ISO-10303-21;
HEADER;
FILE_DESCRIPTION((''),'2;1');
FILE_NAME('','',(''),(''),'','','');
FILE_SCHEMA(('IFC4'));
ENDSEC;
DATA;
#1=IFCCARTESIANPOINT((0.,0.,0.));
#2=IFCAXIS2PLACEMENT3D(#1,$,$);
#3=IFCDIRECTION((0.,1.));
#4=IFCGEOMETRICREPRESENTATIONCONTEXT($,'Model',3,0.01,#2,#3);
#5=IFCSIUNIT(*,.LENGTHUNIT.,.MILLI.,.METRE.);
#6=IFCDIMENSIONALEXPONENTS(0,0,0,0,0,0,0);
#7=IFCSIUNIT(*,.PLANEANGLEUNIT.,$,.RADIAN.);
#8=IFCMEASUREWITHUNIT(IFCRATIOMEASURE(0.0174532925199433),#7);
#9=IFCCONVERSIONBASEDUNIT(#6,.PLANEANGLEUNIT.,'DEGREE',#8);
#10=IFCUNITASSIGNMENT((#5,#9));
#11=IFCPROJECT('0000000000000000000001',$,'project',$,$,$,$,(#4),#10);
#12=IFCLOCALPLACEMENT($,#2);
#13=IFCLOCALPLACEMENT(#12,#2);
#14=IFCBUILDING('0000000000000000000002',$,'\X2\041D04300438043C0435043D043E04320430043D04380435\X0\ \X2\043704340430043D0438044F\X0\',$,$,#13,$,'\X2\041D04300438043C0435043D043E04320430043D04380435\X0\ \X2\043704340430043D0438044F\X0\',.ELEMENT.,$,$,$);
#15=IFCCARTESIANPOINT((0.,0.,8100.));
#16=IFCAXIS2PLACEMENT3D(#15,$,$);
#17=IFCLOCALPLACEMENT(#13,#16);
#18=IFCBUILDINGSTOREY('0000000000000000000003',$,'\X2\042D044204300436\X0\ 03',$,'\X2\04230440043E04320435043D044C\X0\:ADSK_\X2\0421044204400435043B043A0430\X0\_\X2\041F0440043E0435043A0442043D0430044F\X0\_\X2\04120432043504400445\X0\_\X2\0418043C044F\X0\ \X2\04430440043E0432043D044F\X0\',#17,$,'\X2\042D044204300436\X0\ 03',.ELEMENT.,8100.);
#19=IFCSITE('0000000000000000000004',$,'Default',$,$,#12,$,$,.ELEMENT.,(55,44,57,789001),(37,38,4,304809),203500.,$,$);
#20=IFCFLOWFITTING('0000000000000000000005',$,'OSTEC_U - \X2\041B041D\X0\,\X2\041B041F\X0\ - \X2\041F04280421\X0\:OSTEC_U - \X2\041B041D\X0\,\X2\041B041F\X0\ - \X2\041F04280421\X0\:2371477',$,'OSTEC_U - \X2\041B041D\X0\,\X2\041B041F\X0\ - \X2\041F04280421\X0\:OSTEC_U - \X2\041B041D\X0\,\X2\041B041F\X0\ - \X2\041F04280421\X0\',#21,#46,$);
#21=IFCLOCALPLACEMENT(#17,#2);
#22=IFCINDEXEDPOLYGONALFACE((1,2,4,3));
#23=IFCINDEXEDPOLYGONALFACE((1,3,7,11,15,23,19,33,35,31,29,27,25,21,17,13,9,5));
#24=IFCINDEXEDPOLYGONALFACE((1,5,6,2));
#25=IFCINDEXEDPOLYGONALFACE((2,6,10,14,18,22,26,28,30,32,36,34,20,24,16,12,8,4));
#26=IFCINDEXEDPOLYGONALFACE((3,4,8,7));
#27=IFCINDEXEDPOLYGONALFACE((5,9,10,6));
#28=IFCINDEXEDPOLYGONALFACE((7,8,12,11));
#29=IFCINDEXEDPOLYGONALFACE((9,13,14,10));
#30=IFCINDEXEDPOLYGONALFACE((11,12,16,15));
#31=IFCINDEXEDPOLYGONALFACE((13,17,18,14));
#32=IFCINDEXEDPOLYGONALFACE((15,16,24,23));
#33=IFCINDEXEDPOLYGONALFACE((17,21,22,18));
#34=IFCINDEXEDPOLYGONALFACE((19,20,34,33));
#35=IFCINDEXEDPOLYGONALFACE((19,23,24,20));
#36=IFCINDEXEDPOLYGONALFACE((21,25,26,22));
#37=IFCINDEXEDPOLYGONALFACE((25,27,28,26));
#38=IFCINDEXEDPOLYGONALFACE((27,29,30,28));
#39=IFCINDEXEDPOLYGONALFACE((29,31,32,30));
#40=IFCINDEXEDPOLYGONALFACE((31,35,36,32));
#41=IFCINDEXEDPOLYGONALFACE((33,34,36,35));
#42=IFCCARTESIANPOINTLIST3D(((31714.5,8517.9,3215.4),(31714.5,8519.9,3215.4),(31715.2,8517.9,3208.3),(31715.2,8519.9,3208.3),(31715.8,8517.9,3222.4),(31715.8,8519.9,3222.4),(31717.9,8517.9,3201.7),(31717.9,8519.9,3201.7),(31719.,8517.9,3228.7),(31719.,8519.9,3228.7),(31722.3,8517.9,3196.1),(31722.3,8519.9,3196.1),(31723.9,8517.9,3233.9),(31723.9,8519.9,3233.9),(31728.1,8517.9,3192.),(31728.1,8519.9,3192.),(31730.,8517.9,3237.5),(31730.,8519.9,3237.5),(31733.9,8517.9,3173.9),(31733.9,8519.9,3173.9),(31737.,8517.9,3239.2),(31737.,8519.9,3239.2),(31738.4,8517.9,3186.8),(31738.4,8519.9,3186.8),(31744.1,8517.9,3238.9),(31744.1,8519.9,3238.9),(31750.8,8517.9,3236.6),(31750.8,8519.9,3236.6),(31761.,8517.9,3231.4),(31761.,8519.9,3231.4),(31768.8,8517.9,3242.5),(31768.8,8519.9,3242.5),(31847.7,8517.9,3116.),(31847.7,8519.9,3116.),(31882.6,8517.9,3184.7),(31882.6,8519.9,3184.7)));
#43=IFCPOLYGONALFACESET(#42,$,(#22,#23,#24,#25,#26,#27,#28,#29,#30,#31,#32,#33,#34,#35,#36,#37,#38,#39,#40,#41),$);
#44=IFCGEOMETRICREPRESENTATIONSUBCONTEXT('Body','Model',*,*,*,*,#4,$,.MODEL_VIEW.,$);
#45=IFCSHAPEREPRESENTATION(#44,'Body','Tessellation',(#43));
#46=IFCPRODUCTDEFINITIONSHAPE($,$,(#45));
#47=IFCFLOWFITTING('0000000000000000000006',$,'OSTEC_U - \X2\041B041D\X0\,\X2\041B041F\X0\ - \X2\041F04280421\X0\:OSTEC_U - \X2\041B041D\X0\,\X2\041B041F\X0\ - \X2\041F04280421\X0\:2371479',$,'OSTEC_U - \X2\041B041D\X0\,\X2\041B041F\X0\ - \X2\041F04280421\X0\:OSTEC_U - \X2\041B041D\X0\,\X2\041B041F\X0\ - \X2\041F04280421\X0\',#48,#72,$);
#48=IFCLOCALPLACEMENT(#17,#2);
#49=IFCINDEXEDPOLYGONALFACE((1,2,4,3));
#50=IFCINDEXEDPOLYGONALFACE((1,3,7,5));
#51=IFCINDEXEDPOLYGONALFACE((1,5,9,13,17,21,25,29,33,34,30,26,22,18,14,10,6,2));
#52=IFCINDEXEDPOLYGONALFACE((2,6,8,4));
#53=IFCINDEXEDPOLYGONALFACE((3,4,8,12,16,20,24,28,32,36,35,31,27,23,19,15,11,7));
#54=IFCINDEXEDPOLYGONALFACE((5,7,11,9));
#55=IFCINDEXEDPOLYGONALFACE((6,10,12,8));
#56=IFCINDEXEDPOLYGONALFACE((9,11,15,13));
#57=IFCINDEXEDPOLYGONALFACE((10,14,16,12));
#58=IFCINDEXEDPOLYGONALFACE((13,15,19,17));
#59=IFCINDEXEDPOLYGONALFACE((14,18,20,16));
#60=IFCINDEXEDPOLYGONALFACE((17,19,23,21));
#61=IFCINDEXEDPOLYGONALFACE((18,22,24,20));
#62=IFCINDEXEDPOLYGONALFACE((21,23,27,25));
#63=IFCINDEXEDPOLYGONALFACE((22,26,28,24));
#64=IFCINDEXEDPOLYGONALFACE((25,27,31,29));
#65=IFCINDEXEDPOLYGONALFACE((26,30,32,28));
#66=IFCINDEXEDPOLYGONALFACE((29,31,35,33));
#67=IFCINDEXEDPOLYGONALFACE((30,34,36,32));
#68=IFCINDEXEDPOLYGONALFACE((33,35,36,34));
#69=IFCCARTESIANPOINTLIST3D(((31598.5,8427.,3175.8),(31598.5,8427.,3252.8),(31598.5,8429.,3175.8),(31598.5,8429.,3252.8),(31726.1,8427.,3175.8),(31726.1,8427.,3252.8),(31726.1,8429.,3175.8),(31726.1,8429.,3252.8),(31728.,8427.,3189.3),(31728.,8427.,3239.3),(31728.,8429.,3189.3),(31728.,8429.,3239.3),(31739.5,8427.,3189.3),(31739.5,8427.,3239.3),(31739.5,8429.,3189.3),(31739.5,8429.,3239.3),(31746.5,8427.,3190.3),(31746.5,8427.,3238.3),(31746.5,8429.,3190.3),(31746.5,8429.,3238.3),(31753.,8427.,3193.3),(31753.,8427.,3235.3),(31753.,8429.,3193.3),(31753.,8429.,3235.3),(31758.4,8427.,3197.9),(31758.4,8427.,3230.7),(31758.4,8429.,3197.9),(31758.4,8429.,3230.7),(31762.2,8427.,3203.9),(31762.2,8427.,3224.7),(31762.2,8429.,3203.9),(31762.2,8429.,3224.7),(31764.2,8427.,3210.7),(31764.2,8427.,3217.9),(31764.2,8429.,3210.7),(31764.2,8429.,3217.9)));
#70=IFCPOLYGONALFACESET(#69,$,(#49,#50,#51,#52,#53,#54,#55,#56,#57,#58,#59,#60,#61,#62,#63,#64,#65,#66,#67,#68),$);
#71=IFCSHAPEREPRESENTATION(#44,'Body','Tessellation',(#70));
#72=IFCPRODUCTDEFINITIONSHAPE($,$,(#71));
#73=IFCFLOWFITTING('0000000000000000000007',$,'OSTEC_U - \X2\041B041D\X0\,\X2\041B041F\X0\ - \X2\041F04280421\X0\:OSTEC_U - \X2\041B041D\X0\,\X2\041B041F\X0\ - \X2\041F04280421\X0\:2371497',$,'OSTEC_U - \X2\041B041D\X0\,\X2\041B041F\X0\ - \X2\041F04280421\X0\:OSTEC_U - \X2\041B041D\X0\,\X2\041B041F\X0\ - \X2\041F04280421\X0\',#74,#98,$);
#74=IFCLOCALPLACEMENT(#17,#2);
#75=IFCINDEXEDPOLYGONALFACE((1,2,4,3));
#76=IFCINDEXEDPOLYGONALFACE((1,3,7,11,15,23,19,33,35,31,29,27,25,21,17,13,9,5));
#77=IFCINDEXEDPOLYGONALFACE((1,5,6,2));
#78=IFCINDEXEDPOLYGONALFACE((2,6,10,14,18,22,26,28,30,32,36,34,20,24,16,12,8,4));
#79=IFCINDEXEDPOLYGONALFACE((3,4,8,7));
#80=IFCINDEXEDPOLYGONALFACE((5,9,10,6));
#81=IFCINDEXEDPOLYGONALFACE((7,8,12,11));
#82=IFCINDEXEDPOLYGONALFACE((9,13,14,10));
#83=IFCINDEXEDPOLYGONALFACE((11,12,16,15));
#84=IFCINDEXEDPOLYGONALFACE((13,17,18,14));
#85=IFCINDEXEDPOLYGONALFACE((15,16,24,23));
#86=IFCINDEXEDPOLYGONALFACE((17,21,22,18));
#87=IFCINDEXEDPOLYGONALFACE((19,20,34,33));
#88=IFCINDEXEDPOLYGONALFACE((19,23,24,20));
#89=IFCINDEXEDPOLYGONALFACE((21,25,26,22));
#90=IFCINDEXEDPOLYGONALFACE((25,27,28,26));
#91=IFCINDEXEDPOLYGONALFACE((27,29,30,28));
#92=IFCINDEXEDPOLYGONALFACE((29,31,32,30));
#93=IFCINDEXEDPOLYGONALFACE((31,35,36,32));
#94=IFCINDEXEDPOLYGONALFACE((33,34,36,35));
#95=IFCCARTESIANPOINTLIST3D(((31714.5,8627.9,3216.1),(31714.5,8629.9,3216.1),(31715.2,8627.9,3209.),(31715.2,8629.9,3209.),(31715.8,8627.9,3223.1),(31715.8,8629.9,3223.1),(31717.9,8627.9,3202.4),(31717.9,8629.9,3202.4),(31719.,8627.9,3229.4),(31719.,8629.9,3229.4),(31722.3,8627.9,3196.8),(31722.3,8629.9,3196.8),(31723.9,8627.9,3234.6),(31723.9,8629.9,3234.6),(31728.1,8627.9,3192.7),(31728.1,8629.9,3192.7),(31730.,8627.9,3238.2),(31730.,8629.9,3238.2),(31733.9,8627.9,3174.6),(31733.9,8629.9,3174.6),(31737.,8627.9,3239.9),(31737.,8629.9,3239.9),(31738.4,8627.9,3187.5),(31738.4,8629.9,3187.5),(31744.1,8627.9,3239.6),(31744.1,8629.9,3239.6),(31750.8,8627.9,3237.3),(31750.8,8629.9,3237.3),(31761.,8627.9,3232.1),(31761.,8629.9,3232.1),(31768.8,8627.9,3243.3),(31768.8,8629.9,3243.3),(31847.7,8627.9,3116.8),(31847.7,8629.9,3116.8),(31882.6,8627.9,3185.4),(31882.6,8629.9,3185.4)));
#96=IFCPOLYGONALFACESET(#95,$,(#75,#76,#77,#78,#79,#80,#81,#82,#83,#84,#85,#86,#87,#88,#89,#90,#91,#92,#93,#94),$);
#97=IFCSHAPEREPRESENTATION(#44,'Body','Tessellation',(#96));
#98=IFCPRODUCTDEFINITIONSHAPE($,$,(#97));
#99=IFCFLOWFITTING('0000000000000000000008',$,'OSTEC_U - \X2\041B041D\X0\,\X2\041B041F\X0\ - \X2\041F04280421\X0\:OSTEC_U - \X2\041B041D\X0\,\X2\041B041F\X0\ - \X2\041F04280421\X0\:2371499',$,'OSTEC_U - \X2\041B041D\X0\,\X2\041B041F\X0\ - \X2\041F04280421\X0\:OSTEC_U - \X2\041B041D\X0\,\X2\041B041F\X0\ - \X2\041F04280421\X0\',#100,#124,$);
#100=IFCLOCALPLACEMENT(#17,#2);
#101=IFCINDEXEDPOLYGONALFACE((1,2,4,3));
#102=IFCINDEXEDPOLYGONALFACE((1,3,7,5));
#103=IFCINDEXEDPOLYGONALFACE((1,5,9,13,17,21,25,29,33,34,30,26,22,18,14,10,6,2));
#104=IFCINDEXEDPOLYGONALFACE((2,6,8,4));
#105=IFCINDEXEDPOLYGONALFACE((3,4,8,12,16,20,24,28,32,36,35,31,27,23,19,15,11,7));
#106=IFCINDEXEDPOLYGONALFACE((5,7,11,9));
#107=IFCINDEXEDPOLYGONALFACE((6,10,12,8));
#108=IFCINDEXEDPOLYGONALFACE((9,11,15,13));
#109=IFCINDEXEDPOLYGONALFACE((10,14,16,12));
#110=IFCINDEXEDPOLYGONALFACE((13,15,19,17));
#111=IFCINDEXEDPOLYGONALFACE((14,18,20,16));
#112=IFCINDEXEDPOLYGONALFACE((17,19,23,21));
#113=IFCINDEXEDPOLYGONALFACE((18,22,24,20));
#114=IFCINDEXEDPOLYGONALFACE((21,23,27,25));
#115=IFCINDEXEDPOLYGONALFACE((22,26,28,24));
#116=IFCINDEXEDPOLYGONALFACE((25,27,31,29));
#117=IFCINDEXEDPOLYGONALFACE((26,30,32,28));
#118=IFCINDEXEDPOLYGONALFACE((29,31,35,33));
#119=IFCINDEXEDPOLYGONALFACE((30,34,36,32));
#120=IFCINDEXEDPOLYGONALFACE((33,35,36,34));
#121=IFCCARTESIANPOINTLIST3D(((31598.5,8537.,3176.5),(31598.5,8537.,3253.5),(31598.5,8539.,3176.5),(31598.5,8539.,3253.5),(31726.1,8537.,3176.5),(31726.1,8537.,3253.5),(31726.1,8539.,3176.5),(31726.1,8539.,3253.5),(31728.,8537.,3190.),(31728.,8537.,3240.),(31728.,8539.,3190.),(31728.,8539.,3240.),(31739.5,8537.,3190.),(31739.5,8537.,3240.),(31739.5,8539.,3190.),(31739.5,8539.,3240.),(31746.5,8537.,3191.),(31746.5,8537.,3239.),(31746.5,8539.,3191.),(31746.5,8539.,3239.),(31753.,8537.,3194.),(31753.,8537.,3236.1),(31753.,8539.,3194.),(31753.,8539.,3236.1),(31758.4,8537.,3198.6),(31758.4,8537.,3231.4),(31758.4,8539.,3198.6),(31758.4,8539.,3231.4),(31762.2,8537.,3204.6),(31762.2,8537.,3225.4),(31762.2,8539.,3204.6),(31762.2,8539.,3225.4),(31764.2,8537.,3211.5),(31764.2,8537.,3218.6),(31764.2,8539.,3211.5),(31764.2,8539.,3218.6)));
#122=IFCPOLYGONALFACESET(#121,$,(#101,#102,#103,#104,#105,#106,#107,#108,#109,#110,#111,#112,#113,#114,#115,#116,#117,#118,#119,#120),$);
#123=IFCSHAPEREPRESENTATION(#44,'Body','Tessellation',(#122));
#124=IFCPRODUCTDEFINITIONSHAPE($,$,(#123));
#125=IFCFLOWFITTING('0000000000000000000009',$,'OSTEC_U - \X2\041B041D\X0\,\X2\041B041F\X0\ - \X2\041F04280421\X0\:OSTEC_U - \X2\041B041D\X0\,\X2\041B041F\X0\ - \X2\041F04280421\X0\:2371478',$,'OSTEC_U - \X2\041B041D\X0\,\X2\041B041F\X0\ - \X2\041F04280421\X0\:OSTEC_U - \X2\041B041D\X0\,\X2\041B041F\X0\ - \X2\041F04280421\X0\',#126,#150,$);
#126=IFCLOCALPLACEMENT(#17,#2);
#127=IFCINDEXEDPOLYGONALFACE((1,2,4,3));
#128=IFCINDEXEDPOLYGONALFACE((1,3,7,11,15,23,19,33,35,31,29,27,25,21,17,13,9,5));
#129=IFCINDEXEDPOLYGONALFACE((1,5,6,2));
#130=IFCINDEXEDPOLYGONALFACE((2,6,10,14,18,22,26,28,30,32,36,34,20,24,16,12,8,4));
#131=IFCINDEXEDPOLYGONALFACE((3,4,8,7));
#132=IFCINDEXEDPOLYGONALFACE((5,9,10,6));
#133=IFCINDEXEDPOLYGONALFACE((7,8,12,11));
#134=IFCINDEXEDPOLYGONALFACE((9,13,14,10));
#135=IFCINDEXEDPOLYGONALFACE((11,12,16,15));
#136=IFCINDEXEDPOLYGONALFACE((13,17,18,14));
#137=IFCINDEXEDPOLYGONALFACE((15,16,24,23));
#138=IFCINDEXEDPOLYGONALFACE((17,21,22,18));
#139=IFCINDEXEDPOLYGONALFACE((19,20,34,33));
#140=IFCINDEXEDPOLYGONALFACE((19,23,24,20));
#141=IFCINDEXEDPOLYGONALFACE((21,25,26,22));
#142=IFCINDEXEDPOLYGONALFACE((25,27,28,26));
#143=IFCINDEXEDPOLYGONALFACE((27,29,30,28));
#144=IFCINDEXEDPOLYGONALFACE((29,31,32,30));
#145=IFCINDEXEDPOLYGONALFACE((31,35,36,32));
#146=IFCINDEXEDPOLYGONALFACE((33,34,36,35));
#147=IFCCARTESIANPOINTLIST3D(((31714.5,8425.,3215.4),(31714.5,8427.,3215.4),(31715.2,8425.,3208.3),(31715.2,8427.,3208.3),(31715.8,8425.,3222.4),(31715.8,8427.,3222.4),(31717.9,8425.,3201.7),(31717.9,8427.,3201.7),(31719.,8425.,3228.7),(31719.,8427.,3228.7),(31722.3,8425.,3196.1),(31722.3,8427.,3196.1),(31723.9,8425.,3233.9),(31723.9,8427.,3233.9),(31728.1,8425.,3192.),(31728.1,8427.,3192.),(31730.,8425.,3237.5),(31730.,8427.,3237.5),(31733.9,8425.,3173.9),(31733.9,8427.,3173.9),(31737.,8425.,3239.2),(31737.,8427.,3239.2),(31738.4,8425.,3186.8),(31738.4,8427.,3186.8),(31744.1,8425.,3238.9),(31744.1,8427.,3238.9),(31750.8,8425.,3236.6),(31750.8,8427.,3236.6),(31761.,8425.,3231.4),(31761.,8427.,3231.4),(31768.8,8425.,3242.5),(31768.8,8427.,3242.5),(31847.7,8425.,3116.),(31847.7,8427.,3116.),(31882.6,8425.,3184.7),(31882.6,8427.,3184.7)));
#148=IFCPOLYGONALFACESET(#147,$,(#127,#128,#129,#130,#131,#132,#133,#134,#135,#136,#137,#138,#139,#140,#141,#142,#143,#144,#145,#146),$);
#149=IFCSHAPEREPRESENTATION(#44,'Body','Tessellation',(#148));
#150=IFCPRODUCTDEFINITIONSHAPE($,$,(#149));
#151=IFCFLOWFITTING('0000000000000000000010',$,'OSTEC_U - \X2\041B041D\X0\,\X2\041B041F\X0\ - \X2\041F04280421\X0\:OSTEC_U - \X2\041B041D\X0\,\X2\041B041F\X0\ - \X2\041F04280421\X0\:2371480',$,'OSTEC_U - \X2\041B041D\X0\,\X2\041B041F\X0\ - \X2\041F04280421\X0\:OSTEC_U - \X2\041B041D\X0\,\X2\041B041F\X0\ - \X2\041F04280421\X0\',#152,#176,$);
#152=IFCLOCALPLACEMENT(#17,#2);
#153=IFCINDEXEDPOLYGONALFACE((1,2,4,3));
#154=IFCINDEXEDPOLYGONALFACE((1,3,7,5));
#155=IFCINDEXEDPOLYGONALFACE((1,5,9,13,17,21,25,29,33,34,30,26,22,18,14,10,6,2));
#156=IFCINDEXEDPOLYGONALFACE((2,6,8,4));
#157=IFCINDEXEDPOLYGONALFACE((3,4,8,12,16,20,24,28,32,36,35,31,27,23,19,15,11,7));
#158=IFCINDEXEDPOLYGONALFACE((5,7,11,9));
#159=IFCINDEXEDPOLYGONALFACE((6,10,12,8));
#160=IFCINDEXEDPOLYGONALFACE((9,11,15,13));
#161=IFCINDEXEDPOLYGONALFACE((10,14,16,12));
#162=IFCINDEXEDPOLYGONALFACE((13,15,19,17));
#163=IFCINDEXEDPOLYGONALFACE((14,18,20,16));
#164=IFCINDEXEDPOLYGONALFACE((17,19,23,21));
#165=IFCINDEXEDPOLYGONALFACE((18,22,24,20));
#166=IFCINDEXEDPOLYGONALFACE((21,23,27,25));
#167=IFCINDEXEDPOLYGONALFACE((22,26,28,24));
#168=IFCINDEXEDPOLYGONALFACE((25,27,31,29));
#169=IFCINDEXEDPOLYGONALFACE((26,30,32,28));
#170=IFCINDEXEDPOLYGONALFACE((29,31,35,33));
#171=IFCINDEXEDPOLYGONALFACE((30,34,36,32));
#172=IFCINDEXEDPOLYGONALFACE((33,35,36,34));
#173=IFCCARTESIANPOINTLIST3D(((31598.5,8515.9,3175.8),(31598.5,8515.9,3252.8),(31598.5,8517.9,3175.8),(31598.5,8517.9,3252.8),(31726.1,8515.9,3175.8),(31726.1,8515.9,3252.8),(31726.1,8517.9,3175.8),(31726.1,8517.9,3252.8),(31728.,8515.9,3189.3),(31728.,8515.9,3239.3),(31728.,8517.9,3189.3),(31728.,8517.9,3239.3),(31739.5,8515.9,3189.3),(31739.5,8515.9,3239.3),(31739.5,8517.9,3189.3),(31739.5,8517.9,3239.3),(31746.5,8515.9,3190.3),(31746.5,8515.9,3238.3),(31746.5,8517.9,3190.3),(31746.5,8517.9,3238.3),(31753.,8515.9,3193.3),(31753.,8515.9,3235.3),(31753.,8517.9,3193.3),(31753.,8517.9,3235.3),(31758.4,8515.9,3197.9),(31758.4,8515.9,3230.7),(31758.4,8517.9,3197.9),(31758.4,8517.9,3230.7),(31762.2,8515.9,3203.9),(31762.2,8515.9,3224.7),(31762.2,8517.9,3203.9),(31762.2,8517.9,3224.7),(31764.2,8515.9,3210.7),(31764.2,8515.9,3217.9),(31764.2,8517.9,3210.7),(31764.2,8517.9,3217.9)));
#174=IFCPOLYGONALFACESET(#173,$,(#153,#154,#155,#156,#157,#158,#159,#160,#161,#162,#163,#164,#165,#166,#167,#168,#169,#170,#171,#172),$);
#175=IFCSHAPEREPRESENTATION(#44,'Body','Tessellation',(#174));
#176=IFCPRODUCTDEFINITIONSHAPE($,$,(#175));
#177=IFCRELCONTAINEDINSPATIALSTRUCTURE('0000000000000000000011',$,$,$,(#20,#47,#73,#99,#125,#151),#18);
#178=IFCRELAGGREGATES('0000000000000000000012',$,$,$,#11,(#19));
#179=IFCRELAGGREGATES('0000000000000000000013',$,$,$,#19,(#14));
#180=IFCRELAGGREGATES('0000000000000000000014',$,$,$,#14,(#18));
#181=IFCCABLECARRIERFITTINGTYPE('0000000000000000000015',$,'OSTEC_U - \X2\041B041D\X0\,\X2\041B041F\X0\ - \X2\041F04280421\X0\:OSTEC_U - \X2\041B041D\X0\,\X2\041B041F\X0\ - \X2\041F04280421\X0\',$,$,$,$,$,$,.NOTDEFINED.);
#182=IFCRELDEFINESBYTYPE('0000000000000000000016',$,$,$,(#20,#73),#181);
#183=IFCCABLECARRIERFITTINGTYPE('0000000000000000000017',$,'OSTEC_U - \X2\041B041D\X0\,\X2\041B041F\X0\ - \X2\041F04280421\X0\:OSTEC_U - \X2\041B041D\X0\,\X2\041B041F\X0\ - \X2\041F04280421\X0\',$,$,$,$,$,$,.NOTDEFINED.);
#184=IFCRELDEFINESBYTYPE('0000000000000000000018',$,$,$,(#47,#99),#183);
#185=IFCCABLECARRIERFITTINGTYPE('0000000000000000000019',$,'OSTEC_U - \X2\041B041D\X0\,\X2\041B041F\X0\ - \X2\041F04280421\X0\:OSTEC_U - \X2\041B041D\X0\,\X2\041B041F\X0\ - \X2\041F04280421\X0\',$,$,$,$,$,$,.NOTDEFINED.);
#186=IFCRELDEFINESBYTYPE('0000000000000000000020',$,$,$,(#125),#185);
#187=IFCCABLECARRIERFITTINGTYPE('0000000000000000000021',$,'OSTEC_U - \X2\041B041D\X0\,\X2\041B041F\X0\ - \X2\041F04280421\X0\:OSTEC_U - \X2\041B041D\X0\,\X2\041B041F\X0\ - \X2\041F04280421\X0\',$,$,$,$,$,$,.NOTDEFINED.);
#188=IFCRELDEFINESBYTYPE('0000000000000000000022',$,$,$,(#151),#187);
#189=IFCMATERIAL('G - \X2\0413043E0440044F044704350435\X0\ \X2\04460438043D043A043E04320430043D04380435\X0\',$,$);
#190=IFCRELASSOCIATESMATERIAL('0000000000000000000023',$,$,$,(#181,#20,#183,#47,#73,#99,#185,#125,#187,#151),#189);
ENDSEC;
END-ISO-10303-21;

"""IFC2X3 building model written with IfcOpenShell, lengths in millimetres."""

from ifc_helpers import new_model, entity, si_unit, converted_unit, direction, frame, frame_2d, origin, place, context, subcontext, project, spatial, polyline, circle_curve, parameter, trimmed, segment, composite_curve, outline, extrude, source, transform, mapped, material, type_object, type_shapes, element, save


model = new_model("IFC2X3")

# Units and contexts
model_context = context("Model", 3, precision=0.01, world=origin(), true_north=direction((0.0, 1.0)))
body_context = subcontext(model_context, "Body", "Model", "MODEL_VIEW")
ifc_project = project(units=[si_unit("LENGTHUNIT", "METRE", prefix="MILLI"), converted_unit("PLANEANGLEUNIT", "DEGREE", entity("IfcRatioMeasure", 0.0174532925199433), si_unit("PLANEANGLEUNIT", "RADIAN"), dimensions=[0, 0, 0, 0, 0, 0, 0])], contexts=[model_context])

# Site, building, storey
site_placement = place(None, origin())
site = spatial("IfcSite", under=ifc_project, at=site_placement, Name="Default", CompositionType="ELEMENT", RefLatitude=(55, 44, 57, 789001), RefLongitude=(37, 38, 4, 304809), RefElevation=203500.0)
building_placement = place(site_placement, origin())
building = spatial("IfcBuilding", under=site, at=building_placement, Name="Наименование здания", LongName="Наименование здания", CompositionType="ELEMENT")
storey_placement = place(building_placement, frame((0.0, 0.0, 8100.0)))
storey = spatial("IfcBuildingStorey", under=building, at=storey_placement, Name="Этаж 03", ObjectType="Уровень:ADSK_Стрелка_Проектная_Вверх_Имя уровня", LongName="Этаж 03", CompositionType="ELEMENT", Elevation=8100.0)

# Flow fittings
ifc_material_1 = material(Name="G - Горячее цинкование")
cable_carrier_fitting_type_1 = type_object("IfcCableCarrierFittingType", Name="OSTEC_U - ЛН,ЛП - ПШС:OSTEC_U - ЛН,ЛП - ПШС", PredefinedType="NOTDEFINED", material=ifc_material_1)
shared_shape_1 = source(origin(), body_context, "Body", "SweptSolid", [
    extrude(outline(composite_curve([segment(trimmed(circle_curve(frame_2d((-41.5, 0.0), x_axis=(1.0, 0.0)), 25.0), [parameter(90.0)], [parameter(270.0)], True, "PARAMETER"), True, "CONTINUOUS"), segment(polyline([(-41.5, -25.0), (-30.0, -25.0)]), True, "CONTINUOUS"), segment(polyline([(-30.0, -25.0), (-28.1, -38.5)]), True, "CONTINUOUS"), segment(polyline([(-28.1, -38.5), (99.5, -38.5)]), True, "CONTINUOUS"), segment(polyline([(99.5, -38.5), (99.5, 38.5)]), True, "CONTINUOUS"), segment(polyline([(99.5, 38.5), (-28.1, 38.5)]), True, "CONTINUOUS"), segment(polyline([(-28.1, 38.5), (-30.0, 25.0)]), True, "CONTINUOUS"), segment(polyline([(-30.0, 25.0), (-41.5, 25.0)]), True, "CONTINUOUS")], self_intersect=False)), frame((41.5, 0.0, 0.0), z_axis=(0.0, 0.0, -1.0), x_axis=(1.0, 0.0, 0.0)), (0.0, 0.0, -1.0), 2.0),
])
type_shapes(cable_carrier_fitting_type_1, [shared_shape_1])
flow_fitting_1_placement = place(storey_placement, frame((31739.5, 8517.9, 3214.3), z_axis=(0.0, 1.0, 0.0), x_axis=(0.891238, 0.0, -0.453536)))
element("IfcFlowFitting", 1, at=flow_fitting_1_placement, inside=storey, type_object=cable_carrier_fitting_type_1, material=ifc_material_1, Name="OSTEC_U - ЛН,ЛП - ПШС:OSTEC_U - ЛН,ЛП - ПШС:2371477", ObjectType="OSTEC_U - ЛН,ЛП - ПШС:OSTEC_U - ЛН,ЛП - ПШС", context=body_context, shape_type="MappedRepresentation", body=[
    mapped(shared_shape_1, transform((0.0, 0.0, 0.0), scale=1.0)),
])
cable_carrier_fitting_type_2 = type_object("IfcCableCarrierFittingType", Name="OSTEC_U - ЛН,ЛП - ПШС:OSTEC_U - ЛН,ЛП - ПШС", PredefinedType="NOTDEFINED", material=ifc_material_1)
type_shapes(cable_carrier_fitting_type_2, [shared_shape_1])
flow_fitting_2_placement = place(storey_placement, frame((31739.5, 8429.0, 3214.3), z_axis=(0.0, -1.0, 0.0), x_axis=(-1.0, 0.0, 0.0)))
element("IfcFlowFitting", 2, at=flow_fitting_2_placement, inside=storey, type_object=cable_carrier_fitting_type_2, material=ifc_material_1, Name="OSTEC_U - ЛН,ЛП - ПШС:OSTEC_U - ЛН,ЛП - ПШС:2371479", ObjectType="OSTEC_U - ЛН,ЛП - ПШС:OSTEC_U - ЛН,ЛП - ПШС", context=body_context, shape_type="MappedRepresentation", body=[
    mapped(shared_shape_1, transform((0.0, 0.0, 0.0), scale=1.0)),
])
flow_fitting_3_placement = place(storey_placement, frame((31739.5, 8627.9, 3215.0), z_axis=(0.0, 1.0, 0.0), x_axis=(0.891243, 0.0, -0.453526)))
element("IfcFlowFitting", 3, at=flow_fitting_3_placement, inside=storey, type_object=cable_carrier_fitting_type_1, material=ifc_material_1, Name="OSTEC_U - ЛН,ЛП - ПШС:OSTEC_U - ЛН,ЛП - ПШС:2371497", ObjectType="OSTEC_U - ЛН,ЛП - ПШС:OSTEC_U - ЛН,ЛП - ПШС", context=body_context, shape_type="MappedRepresentation", body=[
    mapped(shared_shape_1, transform((0.0, 0.0, 0.0), scale=1.0)),
])
flow_fitting_4_placement = place(storey_placement, frame((31739.5, 8539.0, 3215.0), z_axis=(0.0, -1.0, 0.0), x_axis=(-1.0, 0.0, 0.0)))
element("IfcFlowFitting", 4, at=flow_fitting_4_placement, inside=storey, type_object=cable_carrier_fitting_type_2, material=ifc_material_1, Name="OSTEC_U - ЛН,ЛП - ПШС:OSTEC_U - ЛН,ЛП - ПШС:2371499", ObjectType="OSTEC_U - ЛН,ЛП - ПШС:OSTEC_U - ЛН,ЛП - ПШС", context=body_context, shape_type="MappedRepresentation", body=[
    mapped(shared_shape_1, transform((0.0, 0.0, 0.0), scale=1.0)),
])
cable_carrier_fitting_type_3 = type_object("IfcCableCarrierFittingType", Name="OSTEC_U - ЛН,ЛП - ПШС:OSTEC_U - ЛН,ЛП - ПШС", PredefinedType="NOTDEFINED", material=ifc_material_1)
shared_shape_2 = source(origin(), body_context, "Body", "SweptSolid", [
    extrude(outline(composite_curve([segment(trimmed(circle_curve(frame_2d((-41.5, 0.0), x_axis=(1.0, 0.0)), 25.0), [parameter(90.0)], [parameter(270.0)], True, "PARAMETER"), True, "CONTINUOUS"), segment(polyline([(-41.5, -25.0), (-30.0, -25.0)]), True, "CONTINUOUS"), segment(polyline([(-30.0, -25.0), (-28.1, -38.5)]), True, "CONTINUOUS"), segment(polyline([(-28.1, -38.5), (99.5, -38.5)]), True, "CONTINUOUS"), segment(polyline([(99.5, -38.5), (99.5, 38.5)]), True, "CONTINUOUS"), segment(polyline([(99.5, 38.5), (-28.1, 38.5)]), True, "CONTINUOUS"), segment(polyline([(-28.1, 38.5), (-30.0, 25.0)]), True, "CONTINUOUS"), segment(polyline([(-30.0, 25.0), (-41.5, 25.0)]), True, "CONTINUOUS")], self_intersect=False)), frame((41.5, 0.0, 0.0)), (0.0, 0.0, 1.0), 2.0),
])
type_shapes(cable_carrier_fitting_type_3, [shared_shape_2])
flow_fitting_5_placement = place(storey_placement, frame((31739.5, 8427.0, 3214.3), z_axis=(0.0, -1.0, 0.0), x_axis=(0.891238, 0.0, -0.453536)))
element("IfcFlowFitting", 5, at=flow_fitting_5_placement, inside=storey, type_object=cable_carrier_fitting_type_3, material=ifc_material_1, Name="OSTEC_U - ЛН,ЛП - ПШС:OSTEC_U - ЛН,ЛП - ПШС:2371478", ObjectType="OSTEC_U - ЛН,ЛП - ПШС:OSTEC_U - ЛН,ЛП - ПШС", context=body_context, shape_type="MappedRepresentation", body=[
    mapped(shared_shape_2, transform((0.0, 0.0, 0.0), scale=1.0)),
])
cable_carrier_fitting_type_4 = type_object("IfcCableCarrierFittingType", Name="OSTEC_U - ЛН,ЛП - ПШС:OSTEC_U - ЛН,ЛП - ПШС", PredefinedType="NOTDEFINED", material=ifc_material_1)
type_shapes(cable_carrier_fitting_type_4, [shared_shape_2])
flow_fitting_6_placement = place(storey_placement, frame((31739.5, 8515.9, 3214.3), z_axis=(0.0, 1.0, 0.0), x_axis=(-1.0, 0.0, 0.0)))
element("IfcFlowFitting", 6, at=flow_fitting_6_placement, inside=storey, type_object=cable_carrier_fitting_type_4, material=ifc_material_1, Name="OSTEC_U - ЛН,ЛП - ПШС:OSTEC_U - ЛН,ЛП - ПШС:2371480", ObjectType="OSTEC_U - ЛН,ЛП - ПШС:OSTEC_U - ЛН,ЛП - ПШС", context=body_context, shape_type="MappedRepresentation", body=[
    mapped(shared_shape_2, transform((0.0, 0.0, 0.0), scale=1.0)),
])

save(model, "model.ifc")
